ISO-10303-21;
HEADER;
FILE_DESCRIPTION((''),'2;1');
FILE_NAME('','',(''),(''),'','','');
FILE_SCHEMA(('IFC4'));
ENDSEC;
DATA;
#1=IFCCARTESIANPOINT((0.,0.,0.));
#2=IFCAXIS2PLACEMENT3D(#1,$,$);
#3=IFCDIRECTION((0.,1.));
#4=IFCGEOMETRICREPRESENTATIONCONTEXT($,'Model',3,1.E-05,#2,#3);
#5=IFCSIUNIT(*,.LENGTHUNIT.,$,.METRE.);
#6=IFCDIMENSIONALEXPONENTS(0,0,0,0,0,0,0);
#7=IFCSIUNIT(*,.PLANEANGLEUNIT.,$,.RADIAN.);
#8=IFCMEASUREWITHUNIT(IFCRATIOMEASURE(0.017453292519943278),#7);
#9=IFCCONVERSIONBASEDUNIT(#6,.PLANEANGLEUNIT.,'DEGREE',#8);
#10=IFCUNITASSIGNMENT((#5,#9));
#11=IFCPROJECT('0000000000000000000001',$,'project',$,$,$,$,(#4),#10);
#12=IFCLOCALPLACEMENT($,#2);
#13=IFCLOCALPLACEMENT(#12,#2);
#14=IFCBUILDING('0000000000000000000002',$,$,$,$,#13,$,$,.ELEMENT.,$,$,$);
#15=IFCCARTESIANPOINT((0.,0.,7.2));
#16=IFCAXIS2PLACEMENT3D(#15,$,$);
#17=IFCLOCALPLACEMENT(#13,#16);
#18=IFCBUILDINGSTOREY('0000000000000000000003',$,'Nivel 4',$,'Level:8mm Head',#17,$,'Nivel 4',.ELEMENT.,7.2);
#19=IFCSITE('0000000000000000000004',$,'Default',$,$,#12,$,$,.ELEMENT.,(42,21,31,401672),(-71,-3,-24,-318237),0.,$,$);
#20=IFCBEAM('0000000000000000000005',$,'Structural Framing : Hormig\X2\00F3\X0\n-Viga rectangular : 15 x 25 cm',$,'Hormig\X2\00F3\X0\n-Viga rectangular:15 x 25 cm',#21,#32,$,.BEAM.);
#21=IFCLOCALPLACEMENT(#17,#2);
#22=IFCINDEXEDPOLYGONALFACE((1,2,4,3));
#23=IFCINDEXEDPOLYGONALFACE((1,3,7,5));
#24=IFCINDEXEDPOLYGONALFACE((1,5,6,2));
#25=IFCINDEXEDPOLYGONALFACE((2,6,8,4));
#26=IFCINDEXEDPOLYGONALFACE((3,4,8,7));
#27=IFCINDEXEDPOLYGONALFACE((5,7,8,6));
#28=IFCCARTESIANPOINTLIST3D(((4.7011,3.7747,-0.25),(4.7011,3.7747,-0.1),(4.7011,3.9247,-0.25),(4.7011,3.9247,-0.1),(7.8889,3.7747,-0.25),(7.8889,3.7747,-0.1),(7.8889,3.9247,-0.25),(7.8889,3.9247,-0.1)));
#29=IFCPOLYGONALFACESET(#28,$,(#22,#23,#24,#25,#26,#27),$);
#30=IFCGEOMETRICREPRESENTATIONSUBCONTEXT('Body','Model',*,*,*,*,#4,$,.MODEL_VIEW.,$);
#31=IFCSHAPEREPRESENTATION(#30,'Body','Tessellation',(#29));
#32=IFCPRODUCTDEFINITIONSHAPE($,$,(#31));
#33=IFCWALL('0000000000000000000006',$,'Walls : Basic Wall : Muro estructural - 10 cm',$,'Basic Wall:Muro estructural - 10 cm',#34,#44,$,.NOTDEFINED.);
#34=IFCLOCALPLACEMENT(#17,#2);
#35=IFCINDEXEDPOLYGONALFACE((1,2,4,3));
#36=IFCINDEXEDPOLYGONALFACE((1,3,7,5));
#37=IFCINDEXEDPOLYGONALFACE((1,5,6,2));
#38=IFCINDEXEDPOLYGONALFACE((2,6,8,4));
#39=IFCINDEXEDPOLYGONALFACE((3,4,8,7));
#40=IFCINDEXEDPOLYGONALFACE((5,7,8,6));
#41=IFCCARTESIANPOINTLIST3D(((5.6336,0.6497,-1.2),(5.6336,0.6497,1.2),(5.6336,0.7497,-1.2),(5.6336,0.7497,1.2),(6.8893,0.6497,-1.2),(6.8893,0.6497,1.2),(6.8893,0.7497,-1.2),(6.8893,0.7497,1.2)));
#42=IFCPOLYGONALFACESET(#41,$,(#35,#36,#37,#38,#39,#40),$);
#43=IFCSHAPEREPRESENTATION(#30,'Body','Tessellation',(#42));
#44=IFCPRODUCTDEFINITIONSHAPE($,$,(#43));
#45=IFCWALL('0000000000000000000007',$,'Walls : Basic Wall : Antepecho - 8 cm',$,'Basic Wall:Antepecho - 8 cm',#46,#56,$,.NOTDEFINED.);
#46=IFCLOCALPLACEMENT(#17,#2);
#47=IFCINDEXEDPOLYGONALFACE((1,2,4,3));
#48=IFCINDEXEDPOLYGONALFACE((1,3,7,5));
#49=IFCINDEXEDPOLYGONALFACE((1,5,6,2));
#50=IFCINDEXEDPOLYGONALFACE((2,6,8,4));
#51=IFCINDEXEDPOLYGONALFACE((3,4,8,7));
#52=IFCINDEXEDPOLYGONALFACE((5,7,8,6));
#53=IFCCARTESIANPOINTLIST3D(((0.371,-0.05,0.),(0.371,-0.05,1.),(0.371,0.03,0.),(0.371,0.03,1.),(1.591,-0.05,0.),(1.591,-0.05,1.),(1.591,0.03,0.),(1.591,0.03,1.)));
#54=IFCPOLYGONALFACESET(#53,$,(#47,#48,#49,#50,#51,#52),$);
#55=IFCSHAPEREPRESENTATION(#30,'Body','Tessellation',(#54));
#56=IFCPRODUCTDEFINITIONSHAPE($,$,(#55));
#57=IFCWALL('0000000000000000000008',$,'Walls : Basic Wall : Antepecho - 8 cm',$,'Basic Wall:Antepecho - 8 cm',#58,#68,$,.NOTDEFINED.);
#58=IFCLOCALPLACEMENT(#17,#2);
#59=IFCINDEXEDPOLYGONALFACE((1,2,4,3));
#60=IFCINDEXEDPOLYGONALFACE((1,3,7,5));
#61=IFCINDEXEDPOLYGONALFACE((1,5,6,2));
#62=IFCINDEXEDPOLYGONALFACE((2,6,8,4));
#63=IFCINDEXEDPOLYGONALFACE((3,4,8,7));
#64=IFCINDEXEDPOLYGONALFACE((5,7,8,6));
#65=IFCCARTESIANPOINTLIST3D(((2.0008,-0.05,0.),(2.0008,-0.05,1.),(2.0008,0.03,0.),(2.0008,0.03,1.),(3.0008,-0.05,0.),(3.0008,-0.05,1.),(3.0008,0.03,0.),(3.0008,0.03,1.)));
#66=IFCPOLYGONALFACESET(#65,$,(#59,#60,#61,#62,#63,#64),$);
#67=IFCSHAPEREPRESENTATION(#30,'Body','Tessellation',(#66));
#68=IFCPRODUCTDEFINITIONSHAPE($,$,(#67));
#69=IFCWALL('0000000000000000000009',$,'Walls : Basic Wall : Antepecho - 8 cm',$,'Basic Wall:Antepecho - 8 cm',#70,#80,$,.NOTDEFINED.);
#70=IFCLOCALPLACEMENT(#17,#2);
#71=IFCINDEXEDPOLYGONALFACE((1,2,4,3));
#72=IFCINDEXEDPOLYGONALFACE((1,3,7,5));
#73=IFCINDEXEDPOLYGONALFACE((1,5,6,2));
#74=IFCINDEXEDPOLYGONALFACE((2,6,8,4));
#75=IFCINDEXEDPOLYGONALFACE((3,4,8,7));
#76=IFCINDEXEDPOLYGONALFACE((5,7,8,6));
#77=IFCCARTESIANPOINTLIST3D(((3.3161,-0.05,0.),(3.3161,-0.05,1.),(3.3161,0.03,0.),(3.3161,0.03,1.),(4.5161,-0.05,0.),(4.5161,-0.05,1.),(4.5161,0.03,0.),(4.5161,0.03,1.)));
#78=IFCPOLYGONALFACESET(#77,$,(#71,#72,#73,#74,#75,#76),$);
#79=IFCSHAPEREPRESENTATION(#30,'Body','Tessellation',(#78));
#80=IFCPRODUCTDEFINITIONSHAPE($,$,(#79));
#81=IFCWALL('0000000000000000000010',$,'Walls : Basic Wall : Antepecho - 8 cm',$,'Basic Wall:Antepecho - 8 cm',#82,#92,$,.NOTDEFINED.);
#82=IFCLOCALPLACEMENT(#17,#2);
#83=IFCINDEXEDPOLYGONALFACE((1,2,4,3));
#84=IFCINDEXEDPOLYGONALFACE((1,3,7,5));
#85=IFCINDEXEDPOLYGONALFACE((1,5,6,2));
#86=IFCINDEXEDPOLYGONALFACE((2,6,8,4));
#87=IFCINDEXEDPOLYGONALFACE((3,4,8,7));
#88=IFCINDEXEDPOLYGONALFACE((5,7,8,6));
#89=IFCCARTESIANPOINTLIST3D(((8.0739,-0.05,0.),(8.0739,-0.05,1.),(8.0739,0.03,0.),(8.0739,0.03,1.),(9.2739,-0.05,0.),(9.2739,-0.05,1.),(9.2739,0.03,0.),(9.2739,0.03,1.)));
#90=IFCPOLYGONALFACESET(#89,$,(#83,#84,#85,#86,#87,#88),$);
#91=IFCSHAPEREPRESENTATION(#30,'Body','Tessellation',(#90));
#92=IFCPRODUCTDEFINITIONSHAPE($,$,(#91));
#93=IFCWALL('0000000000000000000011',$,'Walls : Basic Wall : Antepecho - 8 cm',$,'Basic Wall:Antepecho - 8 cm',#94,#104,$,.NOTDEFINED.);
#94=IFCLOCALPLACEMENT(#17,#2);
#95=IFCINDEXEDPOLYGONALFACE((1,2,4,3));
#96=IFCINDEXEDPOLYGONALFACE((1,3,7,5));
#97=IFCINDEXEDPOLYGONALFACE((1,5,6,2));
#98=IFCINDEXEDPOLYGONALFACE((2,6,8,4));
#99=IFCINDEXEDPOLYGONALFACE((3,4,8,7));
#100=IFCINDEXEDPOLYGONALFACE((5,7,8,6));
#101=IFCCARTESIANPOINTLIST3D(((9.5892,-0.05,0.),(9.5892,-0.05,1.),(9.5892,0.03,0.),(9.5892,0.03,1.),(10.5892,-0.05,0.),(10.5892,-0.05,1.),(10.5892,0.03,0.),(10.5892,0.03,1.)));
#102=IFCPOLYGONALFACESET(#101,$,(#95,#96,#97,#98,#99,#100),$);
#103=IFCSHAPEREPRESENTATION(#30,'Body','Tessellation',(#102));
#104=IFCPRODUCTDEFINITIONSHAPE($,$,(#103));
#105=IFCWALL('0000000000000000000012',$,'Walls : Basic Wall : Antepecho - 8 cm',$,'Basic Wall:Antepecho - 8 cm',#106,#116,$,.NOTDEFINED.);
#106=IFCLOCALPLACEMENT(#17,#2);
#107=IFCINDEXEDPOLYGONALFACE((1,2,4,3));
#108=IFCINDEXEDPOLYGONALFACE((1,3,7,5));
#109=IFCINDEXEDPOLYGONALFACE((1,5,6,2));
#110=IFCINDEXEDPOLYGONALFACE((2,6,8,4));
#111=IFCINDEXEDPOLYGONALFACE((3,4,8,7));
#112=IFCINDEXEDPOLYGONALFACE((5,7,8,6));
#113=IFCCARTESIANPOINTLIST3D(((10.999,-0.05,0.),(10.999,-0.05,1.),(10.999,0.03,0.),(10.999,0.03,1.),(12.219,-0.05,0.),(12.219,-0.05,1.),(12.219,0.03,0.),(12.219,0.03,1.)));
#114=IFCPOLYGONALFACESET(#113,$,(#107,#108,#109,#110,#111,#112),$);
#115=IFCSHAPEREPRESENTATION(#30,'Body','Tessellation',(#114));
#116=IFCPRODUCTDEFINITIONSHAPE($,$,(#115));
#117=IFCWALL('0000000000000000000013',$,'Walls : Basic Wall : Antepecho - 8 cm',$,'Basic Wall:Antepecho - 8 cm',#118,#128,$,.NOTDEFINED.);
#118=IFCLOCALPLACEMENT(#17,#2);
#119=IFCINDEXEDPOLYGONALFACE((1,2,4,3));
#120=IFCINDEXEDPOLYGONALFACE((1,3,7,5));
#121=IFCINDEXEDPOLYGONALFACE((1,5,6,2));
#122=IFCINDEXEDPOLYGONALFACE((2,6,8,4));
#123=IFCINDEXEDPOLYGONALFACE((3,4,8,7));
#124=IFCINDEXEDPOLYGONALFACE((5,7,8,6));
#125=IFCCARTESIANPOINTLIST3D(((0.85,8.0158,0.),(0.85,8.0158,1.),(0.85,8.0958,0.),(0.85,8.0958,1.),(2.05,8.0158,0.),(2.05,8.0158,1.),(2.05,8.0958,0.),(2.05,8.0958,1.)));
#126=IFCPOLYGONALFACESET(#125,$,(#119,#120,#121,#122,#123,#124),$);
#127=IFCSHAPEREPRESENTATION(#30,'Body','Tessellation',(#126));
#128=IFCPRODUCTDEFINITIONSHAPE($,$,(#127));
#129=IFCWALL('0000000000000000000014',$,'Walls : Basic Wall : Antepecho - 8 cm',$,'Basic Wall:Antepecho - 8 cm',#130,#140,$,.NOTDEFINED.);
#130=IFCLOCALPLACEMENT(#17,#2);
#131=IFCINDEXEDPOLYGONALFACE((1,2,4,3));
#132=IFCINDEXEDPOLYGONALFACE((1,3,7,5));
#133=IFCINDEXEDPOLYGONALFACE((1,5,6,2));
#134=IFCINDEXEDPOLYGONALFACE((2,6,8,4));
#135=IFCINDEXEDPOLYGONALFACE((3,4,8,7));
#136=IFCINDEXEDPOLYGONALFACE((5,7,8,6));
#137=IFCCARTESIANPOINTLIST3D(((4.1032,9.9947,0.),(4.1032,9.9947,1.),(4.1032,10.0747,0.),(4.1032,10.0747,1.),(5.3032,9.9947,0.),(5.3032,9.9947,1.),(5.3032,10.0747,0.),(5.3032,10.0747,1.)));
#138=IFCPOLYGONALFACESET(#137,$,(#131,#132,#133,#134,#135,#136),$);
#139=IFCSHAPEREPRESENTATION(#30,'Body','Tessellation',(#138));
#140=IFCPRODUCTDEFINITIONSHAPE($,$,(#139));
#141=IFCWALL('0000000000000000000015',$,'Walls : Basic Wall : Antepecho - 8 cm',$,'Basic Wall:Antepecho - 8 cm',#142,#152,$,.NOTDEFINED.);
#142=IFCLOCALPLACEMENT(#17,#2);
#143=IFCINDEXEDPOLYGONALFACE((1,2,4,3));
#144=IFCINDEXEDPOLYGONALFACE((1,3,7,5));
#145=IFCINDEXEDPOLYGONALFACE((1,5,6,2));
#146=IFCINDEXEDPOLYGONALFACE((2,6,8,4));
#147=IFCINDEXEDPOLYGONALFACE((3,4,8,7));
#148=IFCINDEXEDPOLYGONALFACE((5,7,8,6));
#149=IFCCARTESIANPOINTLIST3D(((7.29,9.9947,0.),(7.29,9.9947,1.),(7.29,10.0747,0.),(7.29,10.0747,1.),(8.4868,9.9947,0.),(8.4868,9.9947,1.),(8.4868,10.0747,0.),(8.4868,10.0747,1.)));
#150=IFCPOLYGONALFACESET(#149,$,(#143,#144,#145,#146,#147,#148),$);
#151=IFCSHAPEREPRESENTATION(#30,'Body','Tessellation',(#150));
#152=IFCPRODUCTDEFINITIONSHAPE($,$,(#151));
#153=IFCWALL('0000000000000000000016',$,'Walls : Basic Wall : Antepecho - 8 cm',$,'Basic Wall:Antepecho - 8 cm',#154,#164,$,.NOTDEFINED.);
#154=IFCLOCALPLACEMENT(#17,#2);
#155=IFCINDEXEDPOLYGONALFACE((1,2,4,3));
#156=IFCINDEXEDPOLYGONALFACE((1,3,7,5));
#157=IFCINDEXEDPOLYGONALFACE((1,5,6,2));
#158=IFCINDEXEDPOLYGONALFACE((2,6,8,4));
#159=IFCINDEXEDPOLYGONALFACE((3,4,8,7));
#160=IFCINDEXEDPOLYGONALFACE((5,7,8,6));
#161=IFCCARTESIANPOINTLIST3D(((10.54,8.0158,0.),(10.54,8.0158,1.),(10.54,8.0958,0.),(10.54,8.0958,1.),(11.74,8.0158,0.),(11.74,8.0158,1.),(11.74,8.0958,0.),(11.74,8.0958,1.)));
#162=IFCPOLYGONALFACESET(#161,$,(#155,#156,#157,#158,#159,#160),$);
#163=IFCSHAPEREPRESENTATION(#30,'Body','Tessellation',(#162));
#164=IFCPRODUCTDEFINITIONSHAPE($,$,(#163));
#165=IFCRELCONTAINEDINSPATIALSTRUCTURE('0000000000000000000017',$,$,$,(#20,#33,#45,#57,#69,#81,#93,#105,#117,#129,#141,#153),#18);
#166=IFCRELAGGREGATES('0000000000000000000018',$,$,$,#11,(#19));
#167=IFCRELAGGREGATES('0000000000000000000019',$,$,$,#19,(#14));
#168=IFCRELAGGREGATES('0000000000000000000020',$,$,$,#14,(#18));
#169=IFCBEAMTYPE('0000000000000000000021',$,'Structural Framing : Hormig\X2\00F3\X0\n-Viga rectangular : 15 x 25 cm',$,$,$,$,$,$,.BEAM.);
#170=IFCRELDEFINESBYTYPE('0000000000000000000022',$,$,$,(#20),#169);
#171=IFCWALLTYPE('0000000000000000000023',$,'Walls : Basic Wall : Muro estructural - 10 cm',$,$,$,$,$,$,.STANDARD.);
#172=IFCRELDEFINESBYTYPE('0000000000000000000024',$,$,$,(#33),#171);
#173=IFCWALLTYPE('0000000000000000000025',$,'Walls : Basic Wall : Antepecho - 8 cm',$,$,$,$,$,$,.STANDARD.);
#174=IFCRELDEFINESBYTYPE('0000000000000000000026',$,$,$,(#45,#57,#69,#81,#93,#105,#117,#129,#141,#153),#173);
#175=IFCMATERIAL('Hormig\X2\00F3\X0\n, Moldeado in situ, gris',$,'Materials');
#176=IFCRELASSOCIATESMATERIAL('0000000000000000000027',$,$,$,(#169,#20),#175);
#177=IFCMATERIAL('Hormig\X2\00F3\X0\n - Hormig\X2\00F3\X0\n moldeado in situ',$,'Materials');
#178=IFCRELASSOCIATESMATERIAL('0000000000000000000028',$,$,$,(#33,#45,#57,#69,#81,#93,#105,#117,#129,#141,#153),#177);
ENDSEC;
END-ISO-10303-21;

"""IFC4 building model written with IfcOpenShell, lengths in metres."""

from ifc_helpers import new_model, entity, si_unit, converted_unit, direction, frame, origin, place, context, subcontext, project, spatial, indexed_curve, outline, extrude, source, transform, mapped, material, type_object, type_shapes, element, save


model = new_model("IFC4")

# Units and contexts
model_context = context("Model", 3, precision=1e-05, world=origin(), true_north=direction((0.0, 1.0)))
body_context = subcontext(model_context, "Body", "Model", "MODEL_VIEW")
ifc_project = project(units=[si_unit("LENGTHUNIT", "METRE"), converted_unit("PLANEANGLEUNIT", "DEGREE", entity("IfcRatioMeasure", 0.017453292519943278), si_unit("PLANEANGLEUNIT", "RADIAN"), dimensions=[0, 0, 0, 0, 0, 0, 0])], contexts=[model_context])

# Site, building, storey
site_placement = place(None, origin())
site = spatial("IfcSite", under=ifc_project, at=site_placement, Name="Default", CompositionType="ELEMENT", RefLatitude=(42, 21, 31, 401672), RefLongitude=(-71, -3, -24, -318237), RefElevation=0.0)
building_placement = place(site_placement, origin())
building = spatial("IfcBuilding", under=site, at=building_placement, CompositionType="ELEMENT")
storey_placement = place(building_placement, frame((0.0, 0.0, 7.2)))
storey = spatial("IfcBuildingStorey", under=building, at=storey_placement, Name="Nivel 4", ObjectType="Level:8mm Head", LongName="Nivel 4", CompositionType="ELEMENT", Elevation=7.2)

# Beam
ifc_material_1 = material(Name="Hormigón, Moldeado in situ, gris", Category="Materials")
beam_type_1 = type_object("IfcBeamType", Name="Structural Framing : Hormigón-Viga rectangular : 15 x 25 cm", PredefinedType="BEAM", material=ifc_material_1)
shared_shape_1 = source(origin(), body_context, "Body", "SweptSolid", [
    extrude(outline(indexed_curve([(-0.075, -0.075), (0.075, -0.075), (0.075, 0.075), (-0.075, 0.075), (-0.075, -0.075)], self_intersect=False)), frame((4.7011, 3.8497, 7.025), z_axis=(1.0, 0.0, 0.0), x_axis=(0.0, 0.0, -1.0)), (0.0, 0.0, 1.0), 3.1878),
])
type_shapes(beam_type_1, [shared_shape_1])
beam_1_placement = place(storey_placement, frame((0.0, 0.0, -7.2)))
element("IfcBeam", 1, at=beam_1_placement, inside=storey, type_object=beam_type_1, material=ifc_material_1, Name="Structural Framing : Hormigón-Viga rectangular : 15 x 25 cm", ObjectType="Hormigón-Viga rectangular:15 x 25 cm", PredefinedType="BEAM", context=body_context, shape_type="MappedRepresentation", body=[
    mapped(shared_shape_1, transform((0.0, 0.0, 0.0), scale=1.0)),
])

# Shared definitions
ifc_material_2 = material(Name="Hormigón - Hormigón moldeado in situ", Category="Materials")

# Walls
wall_type_1 = type_object("IfcWallType", Name="Walls : Basic Wall : Muro estructural - 10 cm", PredefinedType="STANDARD")
wall_1_placement = place(storey_placement, frame((5.6336, 0.6997, -1.2)))
element("IfcWall", 2, at=wall_1_placement, inside=storey, type_object=wall_type_1, material=ifc_material_2, Name="Walls : Basic Wall : Muro estructural - 10 cm", ObjectType="Basic Wall:Muro estructural - 10 cm", PredefinedType="NOTDEFINED", context=body_context, shape_type="SweptSolid", body=[
    extrude(outline(indexed_curve([(1.2557, 0.05), (0.0, 0.05), (0.0, -0.05), (1.2557, -0.05), (1.2557, 0.05)], self_intersect=False)), origin(), (0.0, 0.0, 1.0), 2.4),
])
wall_type_2 = type_object("IfcWallType", Name="Walls : Basic Wall : Antepecho - 8 cm", PredefinedType="STANDARD")
wall_2_placement = place(storey_placement, frame((0.371, -0.01, 0.0)))
element("IfcWall", 3, at=wall_2_placement, inside=storey, type_object=wall_type_2, material=ifc_material_2, Name="Walls : Basic Wall : Antepecho - 8 cm", ObjectType="Basic Wall:Antepecho - 8 cm", PredefinedType="NOTDEFINED", context=body_context, shape_type="SweptSolid", body=[
    extrude(outline(indexed_curve([(1.22, 0.04), (0.0, 0.04), (0.0, -0.04), (1.22, -0.04), (1.22, 0.04)], self_intersect=False)), origin(), (0.0, 0.0, 1.0), 1.0),
])
wall_3_placement = place(storey_placement, frame((2.0008, -0.01, 0.0)))
element("IfcWall", 4, at=wall_3_placement, inside=storey, type_object=wall_type_2, material=ifc_material_2, Name="Walls : Basic Wall : Antepecho - 8 cm", ObjectType="Basic Wall:Antepecho - 8 cm", PredefinedType="NOTDEFINED", context=body_context, shape_type="SweptSolid", body=[
    extrude(outline(indexed_curve([(1.0, 0.04), (0.0, 0.04), (0.0, -0.04), (1.0, -0.04), (1.0, 0.04)], self_intersect=False)), origin(), (0.0, 0.0, 1.0), 1.0),
])
wall_4_placement = place(storey_placement, frame((3.3161, -0.01, 0.0)))
element("IfcWall", 5, at=wall_4_placement, inside=storey, type_object=wall_type_2, material=ifc_material_2, Name="Walls : Basic Wall : Antepecho - 8 cm", ObjectType="Basic Wall:Antepecho - 8 cm", PredefinedType="NOTDEFINED", context=body_context, shape_type="SweptSolid", body=[
    extrude(outline(indexed_curve([(1.2, 0.04), (0.0, 0.04), (0.0, -0.04), (1.2, -0.04), (1.2, 0.04)], self_intersect=False)), origin(), (0.0, 0.0, 1.0), 1.0),
])
wall_5_placement = place(storey_placement, frame((8.0739, -0.01, 0.0)))
element("IfcWall", 6, at=wall_5_placement, inside=storey, type_object=wall_type_2, material=ifc_material_2, Name="Walls : Basic Wall : Antepecho - 8 cm", ObjectType="Basic Wall:Antepecho - 8 cm", PredefinedType="NOTDEFINED", context=body_context, shape_type="SweptSolid", body=[
    extrude(outline(indexed_curve([(1.2, 0.04), (0.0, 0.04), (0.0, -0.04), (1.2, -0.04), (1.2, 0.04)], self_intersect=False)), origin(), (0.0, 0.0, 1.0), 1.0),
])
wall_6_placement = place(storey_placement, frame((9.5892, -0.01, 0.0)))
element("IfcWall", 7, at=wall_6_placement, inside=storey, type_object=wall_type_2, material=ifc_material_2, Name="Walls : Basic Wall : Antepecho - 8 cm", ObjectType="Basic Wall:Antepecho - 8 cm", PredefinedType="NOTDEFINED", context=body_context, shape_type="SweptSolid", body=[
    extrude(outline(indexed_curve([(1.0, 0.04), (0.0, 0.04), (0.0, -0.04), (1.0, -0.04), (1.0, 0.04)], self_intersect=False)), origin(), (0.0, 0.0, 1.0), 1.0),
])
wall_7_placement = place(storey_placement, frame((10.999, -0.01, 0.0)))
element("IfcWall", 8, at=wall_7_placement, inside=storey, type_object=wall_type_2, material=ifc_material_2, Name="Walls : Basic Wall : Antepecho - 8 cm", ObjectType="Basic Wall:Antepecho - 8 cm", PredefinedType="NOTDEFINED", context=body_context, shape_type="SweptSolid", body=[
    extrude(outline(indexed_curve([(1.22, 0.04), (0.0, 0.04), (0.0, -0.04), (1.22, -0.04), (1.22, 0.04)], self_intersect=False)), origin(), (0.0, 0.0, 1.0), 1.0),
])
wall_8_placement = place(storey_placement, frame((2.05, 8.0558, 0.0), z_axis=(0.0, 0.0, 1.0), x_axis=(-1.0, 0.0, 0.0)))
element("IfcWall", 9, at=wall_8_placement, inside=storey, type_object=wall_type_2, material=ifc_material_2, Name="Walls : Basic Wall : Antepecho - 8 cm", ObjectType="Basic Wall:Antepecho - 8 cm", PredefinedType="NOTDEFINED", context=body_context, shape_type="SweptSolid", body=[
    extrude(outline(indexed_curve([(1.2, 0.04), (0.0, 0.04), (0.0, -0.04), (1.2, -0.04), (1.2, 0.04)], self_intersect=False)), origin(), (0.0, 0.0, 1.0), 1.0),
])
wall_9_placement = place(storey_placement, frame((5.3032, 10.0347, 0.0), z_axis=(0.0, 0.0, 1.0), x_axis=(-1.0, 0.0, 0.0)))
element("IfcWall", 10, at=wall_9_placement, inside=storey, type_object=wall_type_2, material=ifc_material_2, Name="Walls : Basic Wall : Antepecho - 8 cm", ObjectType="Basic Wall:Antepecho - 8 cm", PredefinedType="NOTDEFINED", context=body_context, shape_type="SweptSolid", body=[
    extrude(outline(indexed_curve([(1.2, 0.04), (0.0, 0.04), (0.0, -0.04), (1.2, -0.04), (1.2, 0.04)], self_intersect=False)), origin(), (0.0, 0.0, 1.0), 1.0),
])
wall_10_placement = place(storey_placement, frame((8.4868, 10.0347, 0.0), z_axis=(0.0, 0.0, 1.0), x_axis=(-1.0, 0.0, 0.0)))
element("IfcWall", 11, at=wall_10_placement, inside=storey, type_object=wall_type_2, material=ifc_material_2, Name="Walls : Basic Wall : Antepecho - 8 cm", ObjectType="Basic Wall:Antepecho - 8 cm", PredefinedType="NOTDEFINED", context=body_context, shape_type="SweptSolid", body=[
    extrude(outline(indexed_curve([(1.1968, 0.04), (0.0, 0.04), (0.0, -0.04), (1.1968, -0.04), (1.1968, 0.04)], self_intersect=False)), origin(), (0.0, 0.0, 1.0), 1.0),
])
wall_11_placement = place(storey_placement, frame((11.74, 8.0558, 0.0), z_axis=(0.0, 0.0, 1.0), x_axis=(-1.0, 0.0, 0.0)))
element("IfcWall", 12, at=wall_11_placement, inside=storey, type_object=wall_type_2, material=ifc_material_2, Name="Walls : Basic Wall : Antepecho - 8 cm", ObjectType="Basic Wall:Antepecho - 8 cm", PredefinedType="NOTDEFINED", context=body_context, shape_type="SweptSolid", body=[
    extrude(outline(indexed_curve([(1.2, 0.04), (0.0, 0.04), (0.0, -0.04), (1.2, -0.04), (1.2, 0.04)], self_intersect=False)), origin(), (0.0, 0.0, 1.0), 1.0),
])

save(model, "model.ifc")
